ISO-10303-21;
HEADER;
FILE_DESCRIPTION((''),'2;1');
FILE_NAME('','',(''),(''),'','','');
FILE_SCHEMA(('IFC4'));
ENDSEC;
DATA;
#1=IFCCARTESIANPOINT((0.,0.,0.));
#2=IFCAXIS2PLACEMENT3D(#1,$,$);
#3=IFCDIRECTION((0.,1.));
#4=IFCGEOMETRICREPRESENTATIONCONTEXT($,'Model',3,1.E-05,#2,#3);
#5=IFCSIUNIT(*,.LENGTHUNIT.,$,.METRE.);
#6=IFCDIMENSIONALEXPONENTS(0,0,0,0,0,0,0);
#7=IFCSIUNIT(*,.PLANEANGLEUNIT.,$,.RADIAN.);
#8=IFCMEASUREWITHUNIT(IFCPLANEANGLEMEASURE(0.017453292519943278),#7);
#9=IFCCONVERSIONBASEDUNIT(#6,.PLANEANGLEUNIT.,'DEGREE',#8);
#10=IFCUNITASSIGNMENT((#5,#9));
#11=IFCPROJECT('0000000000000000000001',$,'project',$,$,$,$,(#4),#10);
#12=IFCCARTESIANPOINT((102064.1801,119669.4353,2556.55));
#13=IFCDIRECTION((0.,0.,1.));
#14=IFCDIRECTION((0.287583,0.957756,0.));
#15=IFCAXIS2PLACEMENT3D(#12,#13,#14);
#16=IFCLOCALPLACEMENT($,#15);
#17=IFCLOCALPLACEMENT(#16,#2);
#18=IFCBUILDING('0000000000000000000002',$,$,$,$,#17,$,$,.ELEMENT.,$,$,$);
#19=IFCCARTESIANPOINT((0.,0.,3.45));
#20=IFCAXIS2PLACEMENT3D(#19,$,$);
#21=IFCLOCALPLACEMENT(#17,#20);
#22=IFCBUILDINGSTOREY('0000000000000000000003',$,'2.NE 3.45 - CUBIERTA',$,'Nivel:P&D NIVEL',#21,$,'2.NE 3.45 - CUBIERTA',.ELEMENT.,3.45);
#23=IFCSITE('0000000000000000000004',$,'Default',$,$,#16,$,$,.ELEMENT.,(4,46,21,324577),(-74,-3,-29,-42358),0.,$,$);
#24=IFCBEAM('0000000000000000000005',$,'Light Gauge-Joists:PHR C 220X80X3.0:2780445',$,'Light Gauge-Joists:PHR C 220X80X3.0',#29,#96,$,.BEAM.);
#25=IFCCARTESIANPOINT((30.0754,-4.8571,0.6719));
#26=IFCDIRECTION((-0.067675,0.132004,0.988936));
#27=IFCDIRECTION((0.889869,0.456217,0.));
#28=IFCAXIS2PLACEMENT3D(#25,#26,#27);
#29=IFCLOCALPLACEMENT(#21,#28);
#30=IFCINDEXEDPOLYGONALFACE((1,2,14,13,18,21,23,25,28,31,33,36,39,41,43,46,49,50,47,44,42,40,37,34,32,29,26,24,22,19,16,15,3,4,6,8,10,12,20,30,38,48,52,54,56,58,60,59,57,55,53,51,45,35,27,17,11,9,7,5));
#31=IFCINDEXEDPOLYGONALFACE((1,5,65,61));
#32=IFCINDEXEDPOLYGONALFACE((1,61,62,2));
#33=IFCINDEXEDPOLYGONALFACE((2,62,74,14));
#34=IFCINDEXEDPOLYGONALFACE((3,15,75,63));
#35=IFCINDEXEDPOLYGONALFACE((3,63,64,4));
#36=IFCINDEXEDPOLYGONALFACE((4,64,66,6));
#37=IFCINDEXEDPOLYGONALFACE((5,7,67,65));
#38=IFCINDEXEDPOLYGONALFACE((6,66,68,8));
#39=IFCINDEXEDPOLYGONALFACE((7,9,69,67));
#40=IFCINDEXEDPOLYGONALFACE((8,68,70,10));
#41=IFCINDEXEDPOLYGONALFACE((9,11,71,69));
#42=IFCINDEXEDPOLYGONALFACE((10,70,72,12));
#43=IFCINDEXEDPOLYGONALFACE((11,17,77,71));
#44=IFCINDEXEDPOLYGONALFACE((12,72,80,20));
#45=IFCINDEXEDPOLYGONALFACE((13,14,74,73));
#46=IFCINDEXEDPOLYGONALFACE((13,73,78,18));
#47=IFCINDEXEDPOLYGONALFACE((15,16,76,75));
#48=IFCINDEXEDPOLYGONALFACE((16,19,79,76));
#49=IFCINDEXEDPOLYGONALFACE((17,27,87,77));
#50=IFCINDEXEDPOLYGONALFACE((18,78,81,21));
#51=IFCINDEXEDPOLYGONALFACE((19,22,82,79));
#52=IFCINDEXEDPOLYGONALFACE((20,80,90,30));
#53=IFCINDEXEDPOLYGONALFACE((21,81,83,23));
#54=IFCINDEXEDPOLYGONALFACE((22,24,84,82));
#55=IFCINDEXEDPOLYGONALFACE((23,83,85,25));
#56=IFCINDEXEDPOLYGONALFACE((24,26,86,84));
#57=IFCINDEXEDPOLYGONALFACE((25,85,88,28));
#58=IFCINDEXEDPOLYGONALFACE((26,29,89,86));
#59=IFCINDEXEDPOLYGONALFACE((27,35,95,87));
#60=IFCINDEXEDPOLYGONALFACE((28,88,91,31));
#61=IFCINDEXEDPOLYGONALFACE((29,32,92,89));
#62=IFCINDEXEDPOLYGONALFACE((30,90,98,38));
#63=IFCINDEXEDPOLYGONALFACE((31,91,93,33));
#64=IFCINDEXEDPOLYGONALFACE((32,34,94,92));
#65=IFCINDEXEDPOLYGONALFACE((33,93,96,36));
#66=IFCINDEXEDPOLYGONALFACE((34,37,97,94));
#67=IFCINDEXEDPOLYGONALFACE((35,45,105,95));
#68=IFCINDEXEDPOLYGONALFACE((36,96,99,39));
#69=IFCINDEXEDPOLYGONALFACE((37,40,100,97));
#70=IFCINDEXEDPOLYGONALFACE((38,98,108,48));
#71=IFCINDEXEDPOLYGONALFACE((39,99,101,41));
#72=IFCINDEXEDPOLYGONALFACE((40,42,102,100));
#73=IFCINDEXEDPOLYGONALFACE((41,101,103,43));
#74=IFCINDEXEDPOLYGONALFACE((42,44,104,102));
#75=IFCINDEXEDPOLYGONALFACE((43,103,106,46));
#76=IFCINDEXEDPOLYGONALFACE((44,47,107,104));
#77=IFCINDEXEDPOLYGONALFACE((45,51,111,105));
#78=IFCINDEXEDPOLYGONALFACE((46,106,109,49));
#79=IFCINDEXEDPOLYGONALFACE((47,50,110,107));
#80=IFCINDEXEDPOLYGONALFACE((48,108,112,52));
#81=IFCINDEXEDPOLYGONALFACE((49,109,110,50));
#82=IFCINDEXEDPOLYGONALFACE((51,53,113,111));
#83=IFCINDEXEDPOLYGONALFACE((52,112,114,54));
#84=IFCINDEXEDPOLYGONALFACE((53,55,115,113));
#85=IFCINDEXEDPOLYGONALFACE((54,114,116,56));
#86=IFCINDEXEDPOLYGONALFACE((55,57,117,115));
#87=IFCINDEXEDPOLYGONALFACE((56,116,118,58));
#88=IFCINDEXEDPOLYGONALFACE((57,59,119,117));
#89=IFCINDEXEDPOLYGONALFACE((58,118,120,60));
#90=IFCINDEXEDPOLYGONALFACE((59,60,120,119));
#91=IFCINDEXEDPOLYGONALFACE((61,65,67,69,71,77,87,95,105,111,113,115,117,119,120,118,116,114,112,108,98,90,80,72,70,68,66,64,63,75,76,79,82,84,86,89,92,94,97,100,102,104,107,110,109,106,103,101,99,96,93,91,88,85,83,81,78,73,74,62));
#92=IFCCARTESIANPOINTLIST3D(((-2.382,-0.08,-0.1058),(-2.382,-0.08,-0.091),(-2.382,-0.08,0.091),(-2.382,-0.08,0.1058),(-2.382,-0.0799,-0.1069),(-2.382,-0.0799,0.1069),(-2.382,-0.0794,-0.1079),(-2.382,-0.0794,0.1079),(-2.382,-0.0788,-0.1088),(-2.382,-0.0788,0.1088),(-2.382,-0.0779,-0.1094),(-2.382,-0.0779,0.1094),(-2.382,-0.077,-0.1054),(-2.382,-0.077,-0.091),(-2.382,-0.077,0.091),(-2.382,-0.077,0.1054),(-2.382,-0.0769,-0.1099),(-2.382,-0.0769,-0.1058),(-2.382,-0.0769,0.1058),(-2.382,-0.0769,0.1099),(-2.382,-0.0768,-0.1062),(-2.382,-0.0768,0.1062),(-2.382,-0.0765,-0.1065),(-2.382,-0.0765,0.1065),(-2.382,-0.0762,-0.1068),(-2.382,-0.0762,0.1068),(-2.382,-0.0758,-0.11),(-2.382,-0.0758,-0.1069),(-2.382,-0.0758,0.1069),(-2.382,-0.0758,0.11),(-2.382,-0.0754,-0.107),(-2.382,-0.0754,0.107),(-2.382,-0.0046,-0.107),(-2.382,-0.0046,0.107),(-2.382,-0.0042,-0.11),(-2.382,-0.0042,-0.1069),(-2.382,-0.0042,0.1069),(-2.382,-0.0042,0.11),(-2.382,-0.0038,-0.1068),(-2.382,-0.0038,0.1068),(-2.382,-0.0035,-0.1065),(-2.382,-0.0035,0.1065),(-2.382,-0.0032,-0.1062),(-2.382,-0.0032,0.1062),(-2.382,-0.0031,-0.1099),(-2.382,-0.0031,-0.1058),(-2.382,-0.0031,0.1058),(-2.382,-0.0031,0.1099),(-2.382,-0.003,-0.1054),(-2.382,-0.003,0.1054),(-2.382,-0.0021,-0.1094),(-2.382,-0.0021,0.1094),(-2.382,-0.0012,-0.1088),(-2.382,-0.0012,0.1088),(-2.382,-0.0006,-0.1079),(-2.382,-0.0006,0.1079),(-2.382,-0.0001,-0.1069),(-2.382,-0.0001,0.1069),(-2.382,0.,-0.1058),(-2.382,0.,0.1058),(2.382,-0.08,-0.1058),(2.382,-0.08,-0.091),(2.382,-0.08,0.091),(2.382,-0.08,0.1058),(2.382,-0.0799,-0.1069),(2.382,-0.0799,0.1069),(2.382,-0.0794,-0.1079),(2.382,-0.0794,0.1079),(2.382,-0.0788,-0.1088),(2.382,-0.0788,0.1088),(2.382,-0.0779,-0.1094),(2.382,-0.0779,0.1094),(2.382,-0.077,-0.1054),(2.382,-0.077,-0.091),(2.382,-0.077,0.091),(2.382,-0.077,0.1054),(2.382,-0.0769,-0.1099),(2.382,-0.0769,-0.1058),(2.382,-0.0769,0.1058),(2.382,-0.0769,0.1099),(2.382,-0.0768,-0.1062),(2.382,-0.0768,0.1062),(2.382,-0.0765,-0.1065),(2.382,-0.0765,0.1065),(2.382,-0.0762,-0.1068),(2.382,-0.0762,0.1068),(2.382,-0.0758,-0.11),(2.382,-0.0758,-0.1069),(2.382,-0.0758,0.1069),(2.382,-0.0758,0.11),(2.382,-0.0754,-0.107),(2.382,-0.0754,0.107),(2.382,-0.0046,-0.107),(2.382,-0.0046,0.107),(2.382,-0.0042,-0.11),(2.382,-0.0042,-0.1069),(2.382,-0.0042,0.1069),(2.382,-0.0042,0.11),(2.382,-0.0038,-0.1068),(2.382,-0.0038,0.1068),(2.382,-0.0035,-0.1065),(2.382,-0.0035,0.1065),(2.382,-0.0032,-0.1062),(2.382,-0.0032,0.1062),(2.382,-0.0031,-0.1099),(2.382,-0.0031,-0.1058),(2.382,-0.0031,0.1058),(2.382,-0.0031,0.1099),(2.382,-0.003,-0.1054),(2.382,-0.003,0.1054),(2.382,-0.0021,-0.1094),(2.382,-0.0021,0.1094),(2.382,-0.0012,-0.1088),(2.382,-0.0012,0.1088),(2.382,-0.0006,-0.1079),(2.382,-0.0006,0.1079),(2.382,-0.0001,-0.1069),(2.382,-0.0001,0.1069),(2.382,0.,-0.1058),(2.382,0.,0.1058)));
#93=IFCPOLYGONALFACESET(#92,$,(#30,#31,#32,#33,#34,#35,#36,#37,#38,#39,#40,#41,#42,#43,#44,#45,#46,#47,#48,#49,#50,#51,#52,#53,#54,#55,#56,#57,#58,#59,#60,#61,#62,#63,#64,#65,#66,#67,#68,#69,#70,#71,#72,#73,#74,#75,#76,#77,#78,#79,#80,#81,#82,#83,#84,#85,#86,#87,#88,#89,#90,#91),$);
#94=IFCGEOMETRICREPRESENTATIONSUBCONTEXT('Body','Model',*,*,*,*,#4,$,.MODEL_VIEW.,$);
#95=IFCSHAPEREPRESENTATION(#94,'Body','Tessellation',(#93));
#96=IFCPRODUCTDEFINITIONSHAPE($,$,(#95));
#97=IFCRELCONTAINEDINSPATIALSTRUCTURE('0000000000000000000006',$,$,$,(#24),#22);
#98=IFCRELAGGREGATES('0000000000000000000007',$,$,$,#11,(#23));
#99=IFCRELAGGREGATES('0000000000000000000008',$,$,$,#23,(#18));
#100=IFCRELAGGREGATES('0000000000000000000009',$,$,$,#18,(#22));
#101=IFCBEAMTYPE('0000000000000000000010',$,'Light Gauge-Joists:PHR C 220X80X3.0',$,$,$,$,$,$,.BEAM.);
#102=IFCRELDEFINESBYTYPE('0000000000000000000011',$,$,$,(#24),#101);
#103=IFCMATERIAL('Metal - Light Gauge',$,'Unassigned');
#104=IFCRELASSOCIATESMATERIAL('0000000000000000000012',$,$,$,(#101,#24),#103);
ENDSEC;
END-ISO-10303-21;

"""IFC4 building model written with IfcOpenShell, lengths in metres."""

from ifc_helpers import new_model, entity, si_unit, converted_unit, direction, frame, origin, place, context, subcontext, project, spatial, line, arc, indexed_curve, outline, extrude, source, transform, mapped, material, type_object, type_shapes, element, save


model = new_model("IFC4")

# Units and contexts
model_context = context("Model", 3, precision=1e-05, world=origin(), true_north=direction((0.0, 1.0)))
body_context = subcontext(model_context, "Body", "Model", "MODEL_VIEW")
ifc_project = project(units=[si_unit("LENGTHUNIT", "METRE"), converted_unit("PLANEANGLEUNIT", "DEGREE", entity("IfcPlaneAngleMeasure", 0.017453292519943278), si_unit("PLANEANGLEUNIT", "RADIAN"), dimensions=[0, 0, 0, 0, 0, 0, 0])], contexts=[model_context])

# Site, building, storey
site_placement = place(None, frame((102064.1801, 119669.4353, 2556.55), z_axis=(0.0, 0.0, 1.0), x_axis=(0.287583, 0.957756, 0.0)))
site = spatial("IfcSite", under=ifc_project, at=site_placement, Name="Default", CompositionType="ELEMENT", RefLatitude=(4, 46, 21, 324577), RefLongitude=(-74, -3, -29, -42358), RefElevation=0.0)
building_placement = place(site_placement, origin())
building = spatial("IfcBuilding", under=site, at=building_placement, CompositionType="ELEMENT")
storey_placement = place(building_placement, frame((0.0, 0.0, 3.45)))
storey = spatial("IfcBuildingStorey", under=building, at=storey_placement, Name="2.NE 3.45 - CUBIERTA", ObjectType="Nivel:P&D NIVEL", LongName="2.NE 3.45 - CUBIERTA", CompositionType="ELEMENT", Elevation=3.45)

# Beam
ifc_material_1 = material(Name="Metal - Light Gauge", Category="Unassigned")
beam_type_1 = type_object("IfcBeamType", Name="Light Gauge-Joists:PHR C 220X80X3.0", PredefinedType="BEAM", material=ifc_material_1)
shared_shape_1 = source(origin(), body_context, "Body", "SweptSolid", [
    extrude(outline(indexed_curve([(-0.1058, -0.0477), (0.1058, -0.0477), (0.1088, -0.0465), (0.11, -0.0435), (0.11, 0.0281), (0.1088, 0.0311), (0.1058, 0.0323), (0.091, 0.0323), (0.091, 0.0293), (0.1054, 0.0293), (0.1065, 0.0288), (0.107, 0.0277), (0.107, -0.0431), (0.1065, -0.0442), (0.1054, -0.0447), (-0.1054, -0.0447), (-0.1065, -0.0442), (-0.107, -0.0431), (-0.107, 0.0277), (-0.1065, 0.0288), (-0.1054, 0.0293), (-0.091, 0.0293), (-0.091, 0.0323), (-0.1058, 0.0323), (-0.1088, 0.0311), (-0.11, 0.0281), (-0.11, -0.0435), (-0.1088, -0.0465)], segments=[line(1, 2), arc(2, 3, 4), line(4, 5), arc(5, 6, 7), line(7, 8, 9, 10), arc(10, 11, 12), line(12, 13), arc(13, 14, 15), line(15, 16), arc(16, 17, 18), line(18, 19), arc(19, 20, 21), line(21, 22, 23, 24), arc(24, 25, 26), line(26, 27), arc(27, 28, 1)], self_intersect=False)), frame((-2.382, -0.0477, 0.0), z_axis=(1.0, 0.0, 0.0), x_axis=(0.0, 0.0, 1.0)), (0.0, 0.0, 1.0), 4.764),
])
type_shapes(beam_type_1, [shared_shape_1])
for number, where, z_axis, x_axis, name in (
    (1, (30.0754, -4.8571, 0.6719), (-0.067675, 0.132004, 0.988936), (0.889869, 0.456217, 0.0), "Light Gauge-Joists:PHR C 220X80X3.0:2780445"),
):
    element("IfcBeam", number, at=place(storey_placement, frame(where, z_axis=z_axis, x_axis=x_axis)), inside=storey, type_object=beam_type_1, material=ifc_material_1, Name=name, ObjectType="Light Gauge-Joists:PHR C 220X80X3.0", PredefinedType="BEAM", context=body_context, shape_type="MappedRepresentation", body=[
        mapped(shared_shape_1, transform((0.0, 0.0, 0.0), scale=1.0)),
    ])

save(model, "model.ifc")
